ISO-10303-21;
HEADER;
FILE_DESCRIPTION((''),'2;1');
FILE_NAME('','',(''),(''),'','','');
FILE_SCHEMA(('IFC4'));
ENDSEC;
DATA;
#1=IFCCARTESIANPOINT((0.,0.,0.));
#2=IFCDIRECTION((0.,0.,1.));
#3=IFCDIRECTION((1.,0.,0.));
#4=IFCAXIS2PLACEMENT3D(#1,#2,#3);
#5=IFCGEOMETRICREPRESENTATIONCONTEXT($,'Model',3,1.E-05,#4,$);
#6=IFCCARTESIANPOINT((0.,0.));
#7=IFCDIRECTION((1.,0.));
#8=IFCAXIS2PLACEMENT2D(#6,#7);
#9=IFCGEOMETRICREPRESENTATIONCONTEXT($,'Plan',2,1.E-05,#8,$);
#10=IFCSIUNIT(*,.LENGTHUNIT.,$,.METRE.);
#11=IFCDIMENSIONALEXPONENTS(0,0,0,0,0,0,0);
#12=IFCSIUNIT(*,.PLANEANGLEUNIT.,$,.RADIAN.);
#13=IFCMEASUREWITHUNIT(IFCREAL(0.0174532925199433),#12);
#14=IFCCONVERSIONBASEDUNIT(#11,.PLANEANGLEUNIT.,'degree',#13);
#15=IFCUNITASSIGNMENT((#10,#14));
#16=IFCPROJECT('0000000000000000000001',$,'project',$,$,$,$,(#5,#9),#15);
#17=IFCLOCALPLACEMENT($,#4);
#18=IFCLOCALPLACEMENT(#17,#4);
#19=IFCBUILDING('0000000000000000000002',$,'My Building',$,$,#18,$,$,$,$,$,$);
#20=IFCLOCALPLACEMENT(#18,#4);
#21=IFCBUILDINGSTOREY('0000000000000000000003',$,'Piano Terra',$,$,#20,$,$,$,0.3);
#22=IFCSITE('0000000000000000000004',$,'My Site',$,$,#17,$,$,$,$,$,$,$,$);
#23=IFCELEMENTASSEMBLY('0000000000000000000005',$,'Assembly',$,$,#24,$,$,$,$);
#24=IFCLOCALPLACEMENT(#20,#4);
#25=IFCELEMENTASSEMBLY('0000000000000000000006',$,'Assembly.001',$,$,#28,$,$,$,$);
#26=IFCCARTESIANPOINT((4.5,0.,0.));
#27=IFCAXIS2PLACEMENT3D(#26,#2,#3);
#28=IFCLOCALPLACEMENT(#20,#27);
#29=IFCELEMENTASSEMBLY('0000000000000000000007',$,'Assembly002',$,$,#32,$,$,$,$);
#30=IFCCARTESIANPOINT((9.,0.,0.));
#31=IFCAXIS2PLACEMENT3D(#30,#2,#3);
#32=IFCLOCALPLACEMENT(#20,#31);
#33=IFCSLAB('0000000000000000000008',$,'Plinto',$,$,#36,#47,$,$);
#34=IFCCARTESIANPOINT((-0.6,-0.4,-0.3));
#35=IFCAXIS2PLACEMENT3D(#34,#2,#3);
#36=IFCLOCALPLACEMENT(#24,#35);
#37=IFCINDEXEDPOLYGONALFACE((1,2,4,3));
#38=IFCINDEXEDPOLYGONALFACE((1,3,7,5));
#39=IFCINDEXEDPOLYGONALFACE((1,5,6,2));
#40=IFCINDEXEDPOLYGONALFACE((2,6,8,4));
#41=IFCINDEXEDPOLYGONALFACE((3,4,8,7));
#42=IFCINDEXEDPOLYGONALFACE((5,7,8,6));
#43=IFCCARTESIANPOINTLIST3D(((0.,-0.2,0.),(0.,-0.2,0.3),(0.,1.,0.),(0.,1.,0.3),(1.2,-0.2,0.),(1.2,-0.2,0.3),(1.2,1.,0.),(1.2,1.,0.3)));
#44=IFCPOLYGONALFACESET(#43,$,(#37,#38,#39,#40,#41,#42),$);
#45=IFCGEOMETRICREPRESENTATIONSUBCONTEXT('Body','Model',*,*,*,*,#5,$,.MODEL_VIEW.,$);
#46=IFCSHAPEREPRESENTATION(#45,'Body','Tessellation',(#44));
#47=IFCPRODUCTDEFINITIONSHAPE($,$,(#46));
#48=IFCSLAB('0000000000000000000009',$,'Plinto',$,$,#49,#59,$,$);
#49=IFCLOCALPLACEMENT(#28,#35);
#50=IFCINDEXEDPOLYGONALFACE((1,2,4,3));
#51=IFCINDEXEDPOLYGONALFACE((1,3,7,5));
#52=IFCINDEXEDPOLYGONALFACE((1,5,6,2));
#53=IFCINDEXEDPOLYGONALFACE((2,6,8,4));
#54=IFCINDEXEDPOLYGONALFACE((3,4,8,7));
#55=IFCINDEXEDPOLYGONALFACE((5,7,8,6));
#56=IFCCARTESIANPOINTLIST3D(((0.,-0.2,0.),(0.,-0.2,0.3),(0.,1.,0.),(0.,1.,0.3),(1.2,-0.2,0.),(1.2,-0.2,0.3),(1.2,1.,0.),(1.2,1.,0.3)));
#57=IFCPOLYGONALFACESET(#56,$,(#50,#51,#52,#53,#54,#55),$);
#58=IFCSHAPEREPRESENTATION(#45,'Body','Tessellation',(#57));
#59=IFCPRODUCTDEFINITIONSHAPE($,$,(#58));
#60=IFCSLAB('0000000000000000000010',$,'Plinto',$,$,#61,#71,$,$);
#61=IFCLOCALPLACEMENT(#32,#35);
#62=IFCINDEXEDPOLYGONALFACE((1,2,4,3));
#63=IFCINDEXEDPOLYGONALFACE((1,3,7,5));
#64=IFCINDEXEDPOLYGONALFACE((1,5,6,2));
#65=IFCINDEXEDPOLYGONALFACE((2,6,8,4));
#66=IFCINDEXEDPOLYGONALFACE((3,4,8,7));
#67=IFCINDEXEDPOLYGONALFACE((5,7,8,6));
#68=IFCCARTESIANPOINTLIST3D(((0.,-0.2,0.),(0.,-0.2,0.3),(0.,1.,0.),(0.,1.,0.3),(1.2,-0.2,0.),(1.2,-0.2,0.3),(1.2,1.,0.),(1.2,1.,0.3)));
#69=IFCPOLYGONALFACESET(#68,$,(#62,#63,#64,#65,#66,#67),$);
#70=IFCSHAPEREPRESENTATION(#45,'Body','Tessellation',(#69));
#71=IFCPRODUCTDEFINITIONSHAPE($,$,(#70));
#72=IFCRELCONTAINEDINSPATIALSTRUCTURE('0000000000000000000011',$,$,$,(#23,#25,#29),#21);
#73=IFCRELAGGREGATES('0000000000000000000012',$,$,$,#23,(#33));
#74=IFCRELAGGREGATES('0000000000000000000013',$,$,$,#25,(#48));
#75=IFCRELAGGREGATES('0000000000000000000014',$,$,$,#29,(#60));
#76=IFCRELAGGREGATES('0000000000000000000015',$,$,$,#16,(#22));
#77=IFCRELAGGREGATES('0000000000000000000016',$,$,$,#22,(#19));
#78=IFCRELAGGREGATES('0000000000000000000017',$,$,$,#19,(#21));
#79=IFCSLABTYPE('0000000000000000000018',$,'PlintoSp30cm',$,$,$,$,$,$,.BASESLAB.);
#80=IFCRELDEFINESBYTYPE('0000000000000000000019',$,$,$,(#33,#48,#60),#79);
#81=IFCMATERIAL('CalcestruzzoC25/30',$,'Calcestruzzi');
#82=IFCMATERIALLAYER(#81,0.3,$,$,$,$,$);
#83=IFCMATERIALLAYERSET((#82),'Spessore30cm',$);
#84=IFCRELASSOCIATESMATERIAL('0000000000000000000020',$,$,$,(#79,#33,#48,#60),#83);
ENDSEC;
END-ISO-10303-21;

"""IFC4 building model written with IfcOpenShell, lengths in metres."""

from ifc_helpers import new_model, entity, si_unit, converted_unit, frame, origin_with_axes, origin_2d_with_axis, place, context, subcontext, project, spatial, line, indexed_curve, outline, extrude, material, layer, layer_set, layer_usage, type_object, element, aggregate, save


model = new_model("IFC4")

# Units and contexts
model_context = context("Model", 3, precision=1e-05, world=origin_with_axes())
plan_context = context("Plan", 2, precision=1e-05, world=origin_2d_with_axis())
body_context = subcontext(model_context, "Body", "Model", "MODEL_VIEW")
ifc_project = project(units=[si_unit("LENGTHUNIT", "METRE"), converted_unit("PLANEANGLEUNIT", "degree", entity("IfcReal", 0.0174532925199433), si_unit("PLANEANGLEUNIT", "RADIAN"), dimensions=[0, 0, 0, 0, 0, 0, 0])], contexts=[model_context, plan_context])

# Site, building, storey
site_placement = place(None, origin_with_axes())
site = spatial("IfcSite", under=ifc_project, at=site_placement, Name="My Site")
building_placement = place(site_placement, origin_with_axes())
building = spatial("IfcBuilding", under=site, at=building_placement, Name="My Building")
storey_placement = place(building_placement, origin_with_axes())
storey = spatial("IfcBuildingStorey", under=building, at=storey_placement, Name="Piano Terra", Elevation=0.3)

# Element assemblies
assembly_1_placement = place(storey_placement, origin_with_axes())
assembly_1 = element("IfcElementAssembly", 1, at=assembly_1_placement, inside=storey, Name="Assembly")
assembly_2_placement = place(storey_placement, frame((4.5, 0.0, 0.0), z_axis=(0.0, 0.0, 1.0), x_axis=(1.0, 0.0, 0.0)))
assembly_2 = element("IfcElementAssembly", 2, at=assembly_2_placement, inside=storey, Name="Assembly.001")
assembly_3_placement = place(storey_placement, frame((9.0, 0.0, 0.0), z_axis=(0.0, 0.0, 1.0), x_axis=(1.0, 0.0, 0.0)))
assembly_3 = element("IfcElementAssembly", 3, at=assembly_3_placement, inside=storey, Name="Assembly002")

# Slabs
ifc_material_1 = material(Name="CalcestruzzoC25/30", Category="Calcestruzzi")
ifc_layer = layer(ifc_material_1, 0.3)
ifc_layer_set = layer_set([ifc_layer], Name="Spessore30cm")
ifc_layer_usage_1 = layer_usage(ifc_layer_set, "AXIS3", "POSITIVE", 0.0)
slab_type_1 = type_object("IfcSlabType", Name="PlintoSp30cm", PredefinedType="BASESLAB", material=ifc_layer_set)
slab_1_placement = place(assembly_1_placement, frame((-0.6, -0.4, -0.3), z_axis=(0.0, 0.0, 1.0), x_axis=(1.0, 0.0, 0.0)))
slab_1 = element("IfcSlab", 4, at=slab_1_placement, type_object=slab_type_1, material=ifc_layer_usage_1, Name="Plinto", context=body_context, shape_type="SweptSolid", body=[
    extrude(outline(indexed_curve([(0.0, 1.0), (1.2, 1.0), (1.2, -0.2), (0.0, -0.2)], segments=[line(4, 1), line(1, 2), line(2, 3), line(3, 4)], self_intersect=False)), None, (0.0, 0.0, 1.0), 0.3),
])
aggregate(assembly_1, [slab_1])
ifc_layer_usage_2 = layer_usage(ifc_layer_set, "AXIS3", "POSITIVE", 0.0)
slab_2_placement = place(assembly_2_placement, frame((-0.6, -0.4, -0.3), z_axis=(0.0, 0.0, 1.0), x_axis=(1.0, 0.0, 0.0)))
slab_2 = element("IfcSlab", 5, at=slab_2_placement, type_object=slab_type_1, material=ifc_layer_usage_2, Name="Plinto", context=body_context, shape_type="SweptSolid", body=[
    extrude(outline(indexed_curve([(0.0, 1.0), (1.2, 1.0), (1.2, -0.2), (0.0, -0.2)], segments=[line(4, 1), line(1, 2), line(2, 3), line(3, 4)], self_intersect=False)), None, (0.0, 0.0, 1.0), 0.3),
])
aggregate(assembly_2, [slab_2])
ifc_layer_usage_3 = layer_usage(ifc_layer_set, "AXIS3", "POSITIVE", 0.0)
slab_3_placement = place(assembly_3_placement, frame((-0.6, -0.4, -0.3), z_axis=(0.0, 0.0, 1.0), x_axis=(1.0, 0.0, 0.0)))
slab_3 = element("IfcSlab", 6, at=slab_3_placement, type_object=slab_type_1, material=ifc_layer_usage_3, Name="Plinto", context=body_context, shape_type="SweptSolid", body=[
    extrude(outline(indexed_curve([(0.0, 1.0), (1.2, 1.0), (1.2, -0.2), (0.0, -0.2)], segments=[line(4, 1), line(1, 2), line(2, 3), line(3, 4)], self_intersect=False)), None, (0.0, 0.0, 1.0), 0.3),
])
aggregate(assembly_3, [slab_3])

save(model, "model.ifc")
